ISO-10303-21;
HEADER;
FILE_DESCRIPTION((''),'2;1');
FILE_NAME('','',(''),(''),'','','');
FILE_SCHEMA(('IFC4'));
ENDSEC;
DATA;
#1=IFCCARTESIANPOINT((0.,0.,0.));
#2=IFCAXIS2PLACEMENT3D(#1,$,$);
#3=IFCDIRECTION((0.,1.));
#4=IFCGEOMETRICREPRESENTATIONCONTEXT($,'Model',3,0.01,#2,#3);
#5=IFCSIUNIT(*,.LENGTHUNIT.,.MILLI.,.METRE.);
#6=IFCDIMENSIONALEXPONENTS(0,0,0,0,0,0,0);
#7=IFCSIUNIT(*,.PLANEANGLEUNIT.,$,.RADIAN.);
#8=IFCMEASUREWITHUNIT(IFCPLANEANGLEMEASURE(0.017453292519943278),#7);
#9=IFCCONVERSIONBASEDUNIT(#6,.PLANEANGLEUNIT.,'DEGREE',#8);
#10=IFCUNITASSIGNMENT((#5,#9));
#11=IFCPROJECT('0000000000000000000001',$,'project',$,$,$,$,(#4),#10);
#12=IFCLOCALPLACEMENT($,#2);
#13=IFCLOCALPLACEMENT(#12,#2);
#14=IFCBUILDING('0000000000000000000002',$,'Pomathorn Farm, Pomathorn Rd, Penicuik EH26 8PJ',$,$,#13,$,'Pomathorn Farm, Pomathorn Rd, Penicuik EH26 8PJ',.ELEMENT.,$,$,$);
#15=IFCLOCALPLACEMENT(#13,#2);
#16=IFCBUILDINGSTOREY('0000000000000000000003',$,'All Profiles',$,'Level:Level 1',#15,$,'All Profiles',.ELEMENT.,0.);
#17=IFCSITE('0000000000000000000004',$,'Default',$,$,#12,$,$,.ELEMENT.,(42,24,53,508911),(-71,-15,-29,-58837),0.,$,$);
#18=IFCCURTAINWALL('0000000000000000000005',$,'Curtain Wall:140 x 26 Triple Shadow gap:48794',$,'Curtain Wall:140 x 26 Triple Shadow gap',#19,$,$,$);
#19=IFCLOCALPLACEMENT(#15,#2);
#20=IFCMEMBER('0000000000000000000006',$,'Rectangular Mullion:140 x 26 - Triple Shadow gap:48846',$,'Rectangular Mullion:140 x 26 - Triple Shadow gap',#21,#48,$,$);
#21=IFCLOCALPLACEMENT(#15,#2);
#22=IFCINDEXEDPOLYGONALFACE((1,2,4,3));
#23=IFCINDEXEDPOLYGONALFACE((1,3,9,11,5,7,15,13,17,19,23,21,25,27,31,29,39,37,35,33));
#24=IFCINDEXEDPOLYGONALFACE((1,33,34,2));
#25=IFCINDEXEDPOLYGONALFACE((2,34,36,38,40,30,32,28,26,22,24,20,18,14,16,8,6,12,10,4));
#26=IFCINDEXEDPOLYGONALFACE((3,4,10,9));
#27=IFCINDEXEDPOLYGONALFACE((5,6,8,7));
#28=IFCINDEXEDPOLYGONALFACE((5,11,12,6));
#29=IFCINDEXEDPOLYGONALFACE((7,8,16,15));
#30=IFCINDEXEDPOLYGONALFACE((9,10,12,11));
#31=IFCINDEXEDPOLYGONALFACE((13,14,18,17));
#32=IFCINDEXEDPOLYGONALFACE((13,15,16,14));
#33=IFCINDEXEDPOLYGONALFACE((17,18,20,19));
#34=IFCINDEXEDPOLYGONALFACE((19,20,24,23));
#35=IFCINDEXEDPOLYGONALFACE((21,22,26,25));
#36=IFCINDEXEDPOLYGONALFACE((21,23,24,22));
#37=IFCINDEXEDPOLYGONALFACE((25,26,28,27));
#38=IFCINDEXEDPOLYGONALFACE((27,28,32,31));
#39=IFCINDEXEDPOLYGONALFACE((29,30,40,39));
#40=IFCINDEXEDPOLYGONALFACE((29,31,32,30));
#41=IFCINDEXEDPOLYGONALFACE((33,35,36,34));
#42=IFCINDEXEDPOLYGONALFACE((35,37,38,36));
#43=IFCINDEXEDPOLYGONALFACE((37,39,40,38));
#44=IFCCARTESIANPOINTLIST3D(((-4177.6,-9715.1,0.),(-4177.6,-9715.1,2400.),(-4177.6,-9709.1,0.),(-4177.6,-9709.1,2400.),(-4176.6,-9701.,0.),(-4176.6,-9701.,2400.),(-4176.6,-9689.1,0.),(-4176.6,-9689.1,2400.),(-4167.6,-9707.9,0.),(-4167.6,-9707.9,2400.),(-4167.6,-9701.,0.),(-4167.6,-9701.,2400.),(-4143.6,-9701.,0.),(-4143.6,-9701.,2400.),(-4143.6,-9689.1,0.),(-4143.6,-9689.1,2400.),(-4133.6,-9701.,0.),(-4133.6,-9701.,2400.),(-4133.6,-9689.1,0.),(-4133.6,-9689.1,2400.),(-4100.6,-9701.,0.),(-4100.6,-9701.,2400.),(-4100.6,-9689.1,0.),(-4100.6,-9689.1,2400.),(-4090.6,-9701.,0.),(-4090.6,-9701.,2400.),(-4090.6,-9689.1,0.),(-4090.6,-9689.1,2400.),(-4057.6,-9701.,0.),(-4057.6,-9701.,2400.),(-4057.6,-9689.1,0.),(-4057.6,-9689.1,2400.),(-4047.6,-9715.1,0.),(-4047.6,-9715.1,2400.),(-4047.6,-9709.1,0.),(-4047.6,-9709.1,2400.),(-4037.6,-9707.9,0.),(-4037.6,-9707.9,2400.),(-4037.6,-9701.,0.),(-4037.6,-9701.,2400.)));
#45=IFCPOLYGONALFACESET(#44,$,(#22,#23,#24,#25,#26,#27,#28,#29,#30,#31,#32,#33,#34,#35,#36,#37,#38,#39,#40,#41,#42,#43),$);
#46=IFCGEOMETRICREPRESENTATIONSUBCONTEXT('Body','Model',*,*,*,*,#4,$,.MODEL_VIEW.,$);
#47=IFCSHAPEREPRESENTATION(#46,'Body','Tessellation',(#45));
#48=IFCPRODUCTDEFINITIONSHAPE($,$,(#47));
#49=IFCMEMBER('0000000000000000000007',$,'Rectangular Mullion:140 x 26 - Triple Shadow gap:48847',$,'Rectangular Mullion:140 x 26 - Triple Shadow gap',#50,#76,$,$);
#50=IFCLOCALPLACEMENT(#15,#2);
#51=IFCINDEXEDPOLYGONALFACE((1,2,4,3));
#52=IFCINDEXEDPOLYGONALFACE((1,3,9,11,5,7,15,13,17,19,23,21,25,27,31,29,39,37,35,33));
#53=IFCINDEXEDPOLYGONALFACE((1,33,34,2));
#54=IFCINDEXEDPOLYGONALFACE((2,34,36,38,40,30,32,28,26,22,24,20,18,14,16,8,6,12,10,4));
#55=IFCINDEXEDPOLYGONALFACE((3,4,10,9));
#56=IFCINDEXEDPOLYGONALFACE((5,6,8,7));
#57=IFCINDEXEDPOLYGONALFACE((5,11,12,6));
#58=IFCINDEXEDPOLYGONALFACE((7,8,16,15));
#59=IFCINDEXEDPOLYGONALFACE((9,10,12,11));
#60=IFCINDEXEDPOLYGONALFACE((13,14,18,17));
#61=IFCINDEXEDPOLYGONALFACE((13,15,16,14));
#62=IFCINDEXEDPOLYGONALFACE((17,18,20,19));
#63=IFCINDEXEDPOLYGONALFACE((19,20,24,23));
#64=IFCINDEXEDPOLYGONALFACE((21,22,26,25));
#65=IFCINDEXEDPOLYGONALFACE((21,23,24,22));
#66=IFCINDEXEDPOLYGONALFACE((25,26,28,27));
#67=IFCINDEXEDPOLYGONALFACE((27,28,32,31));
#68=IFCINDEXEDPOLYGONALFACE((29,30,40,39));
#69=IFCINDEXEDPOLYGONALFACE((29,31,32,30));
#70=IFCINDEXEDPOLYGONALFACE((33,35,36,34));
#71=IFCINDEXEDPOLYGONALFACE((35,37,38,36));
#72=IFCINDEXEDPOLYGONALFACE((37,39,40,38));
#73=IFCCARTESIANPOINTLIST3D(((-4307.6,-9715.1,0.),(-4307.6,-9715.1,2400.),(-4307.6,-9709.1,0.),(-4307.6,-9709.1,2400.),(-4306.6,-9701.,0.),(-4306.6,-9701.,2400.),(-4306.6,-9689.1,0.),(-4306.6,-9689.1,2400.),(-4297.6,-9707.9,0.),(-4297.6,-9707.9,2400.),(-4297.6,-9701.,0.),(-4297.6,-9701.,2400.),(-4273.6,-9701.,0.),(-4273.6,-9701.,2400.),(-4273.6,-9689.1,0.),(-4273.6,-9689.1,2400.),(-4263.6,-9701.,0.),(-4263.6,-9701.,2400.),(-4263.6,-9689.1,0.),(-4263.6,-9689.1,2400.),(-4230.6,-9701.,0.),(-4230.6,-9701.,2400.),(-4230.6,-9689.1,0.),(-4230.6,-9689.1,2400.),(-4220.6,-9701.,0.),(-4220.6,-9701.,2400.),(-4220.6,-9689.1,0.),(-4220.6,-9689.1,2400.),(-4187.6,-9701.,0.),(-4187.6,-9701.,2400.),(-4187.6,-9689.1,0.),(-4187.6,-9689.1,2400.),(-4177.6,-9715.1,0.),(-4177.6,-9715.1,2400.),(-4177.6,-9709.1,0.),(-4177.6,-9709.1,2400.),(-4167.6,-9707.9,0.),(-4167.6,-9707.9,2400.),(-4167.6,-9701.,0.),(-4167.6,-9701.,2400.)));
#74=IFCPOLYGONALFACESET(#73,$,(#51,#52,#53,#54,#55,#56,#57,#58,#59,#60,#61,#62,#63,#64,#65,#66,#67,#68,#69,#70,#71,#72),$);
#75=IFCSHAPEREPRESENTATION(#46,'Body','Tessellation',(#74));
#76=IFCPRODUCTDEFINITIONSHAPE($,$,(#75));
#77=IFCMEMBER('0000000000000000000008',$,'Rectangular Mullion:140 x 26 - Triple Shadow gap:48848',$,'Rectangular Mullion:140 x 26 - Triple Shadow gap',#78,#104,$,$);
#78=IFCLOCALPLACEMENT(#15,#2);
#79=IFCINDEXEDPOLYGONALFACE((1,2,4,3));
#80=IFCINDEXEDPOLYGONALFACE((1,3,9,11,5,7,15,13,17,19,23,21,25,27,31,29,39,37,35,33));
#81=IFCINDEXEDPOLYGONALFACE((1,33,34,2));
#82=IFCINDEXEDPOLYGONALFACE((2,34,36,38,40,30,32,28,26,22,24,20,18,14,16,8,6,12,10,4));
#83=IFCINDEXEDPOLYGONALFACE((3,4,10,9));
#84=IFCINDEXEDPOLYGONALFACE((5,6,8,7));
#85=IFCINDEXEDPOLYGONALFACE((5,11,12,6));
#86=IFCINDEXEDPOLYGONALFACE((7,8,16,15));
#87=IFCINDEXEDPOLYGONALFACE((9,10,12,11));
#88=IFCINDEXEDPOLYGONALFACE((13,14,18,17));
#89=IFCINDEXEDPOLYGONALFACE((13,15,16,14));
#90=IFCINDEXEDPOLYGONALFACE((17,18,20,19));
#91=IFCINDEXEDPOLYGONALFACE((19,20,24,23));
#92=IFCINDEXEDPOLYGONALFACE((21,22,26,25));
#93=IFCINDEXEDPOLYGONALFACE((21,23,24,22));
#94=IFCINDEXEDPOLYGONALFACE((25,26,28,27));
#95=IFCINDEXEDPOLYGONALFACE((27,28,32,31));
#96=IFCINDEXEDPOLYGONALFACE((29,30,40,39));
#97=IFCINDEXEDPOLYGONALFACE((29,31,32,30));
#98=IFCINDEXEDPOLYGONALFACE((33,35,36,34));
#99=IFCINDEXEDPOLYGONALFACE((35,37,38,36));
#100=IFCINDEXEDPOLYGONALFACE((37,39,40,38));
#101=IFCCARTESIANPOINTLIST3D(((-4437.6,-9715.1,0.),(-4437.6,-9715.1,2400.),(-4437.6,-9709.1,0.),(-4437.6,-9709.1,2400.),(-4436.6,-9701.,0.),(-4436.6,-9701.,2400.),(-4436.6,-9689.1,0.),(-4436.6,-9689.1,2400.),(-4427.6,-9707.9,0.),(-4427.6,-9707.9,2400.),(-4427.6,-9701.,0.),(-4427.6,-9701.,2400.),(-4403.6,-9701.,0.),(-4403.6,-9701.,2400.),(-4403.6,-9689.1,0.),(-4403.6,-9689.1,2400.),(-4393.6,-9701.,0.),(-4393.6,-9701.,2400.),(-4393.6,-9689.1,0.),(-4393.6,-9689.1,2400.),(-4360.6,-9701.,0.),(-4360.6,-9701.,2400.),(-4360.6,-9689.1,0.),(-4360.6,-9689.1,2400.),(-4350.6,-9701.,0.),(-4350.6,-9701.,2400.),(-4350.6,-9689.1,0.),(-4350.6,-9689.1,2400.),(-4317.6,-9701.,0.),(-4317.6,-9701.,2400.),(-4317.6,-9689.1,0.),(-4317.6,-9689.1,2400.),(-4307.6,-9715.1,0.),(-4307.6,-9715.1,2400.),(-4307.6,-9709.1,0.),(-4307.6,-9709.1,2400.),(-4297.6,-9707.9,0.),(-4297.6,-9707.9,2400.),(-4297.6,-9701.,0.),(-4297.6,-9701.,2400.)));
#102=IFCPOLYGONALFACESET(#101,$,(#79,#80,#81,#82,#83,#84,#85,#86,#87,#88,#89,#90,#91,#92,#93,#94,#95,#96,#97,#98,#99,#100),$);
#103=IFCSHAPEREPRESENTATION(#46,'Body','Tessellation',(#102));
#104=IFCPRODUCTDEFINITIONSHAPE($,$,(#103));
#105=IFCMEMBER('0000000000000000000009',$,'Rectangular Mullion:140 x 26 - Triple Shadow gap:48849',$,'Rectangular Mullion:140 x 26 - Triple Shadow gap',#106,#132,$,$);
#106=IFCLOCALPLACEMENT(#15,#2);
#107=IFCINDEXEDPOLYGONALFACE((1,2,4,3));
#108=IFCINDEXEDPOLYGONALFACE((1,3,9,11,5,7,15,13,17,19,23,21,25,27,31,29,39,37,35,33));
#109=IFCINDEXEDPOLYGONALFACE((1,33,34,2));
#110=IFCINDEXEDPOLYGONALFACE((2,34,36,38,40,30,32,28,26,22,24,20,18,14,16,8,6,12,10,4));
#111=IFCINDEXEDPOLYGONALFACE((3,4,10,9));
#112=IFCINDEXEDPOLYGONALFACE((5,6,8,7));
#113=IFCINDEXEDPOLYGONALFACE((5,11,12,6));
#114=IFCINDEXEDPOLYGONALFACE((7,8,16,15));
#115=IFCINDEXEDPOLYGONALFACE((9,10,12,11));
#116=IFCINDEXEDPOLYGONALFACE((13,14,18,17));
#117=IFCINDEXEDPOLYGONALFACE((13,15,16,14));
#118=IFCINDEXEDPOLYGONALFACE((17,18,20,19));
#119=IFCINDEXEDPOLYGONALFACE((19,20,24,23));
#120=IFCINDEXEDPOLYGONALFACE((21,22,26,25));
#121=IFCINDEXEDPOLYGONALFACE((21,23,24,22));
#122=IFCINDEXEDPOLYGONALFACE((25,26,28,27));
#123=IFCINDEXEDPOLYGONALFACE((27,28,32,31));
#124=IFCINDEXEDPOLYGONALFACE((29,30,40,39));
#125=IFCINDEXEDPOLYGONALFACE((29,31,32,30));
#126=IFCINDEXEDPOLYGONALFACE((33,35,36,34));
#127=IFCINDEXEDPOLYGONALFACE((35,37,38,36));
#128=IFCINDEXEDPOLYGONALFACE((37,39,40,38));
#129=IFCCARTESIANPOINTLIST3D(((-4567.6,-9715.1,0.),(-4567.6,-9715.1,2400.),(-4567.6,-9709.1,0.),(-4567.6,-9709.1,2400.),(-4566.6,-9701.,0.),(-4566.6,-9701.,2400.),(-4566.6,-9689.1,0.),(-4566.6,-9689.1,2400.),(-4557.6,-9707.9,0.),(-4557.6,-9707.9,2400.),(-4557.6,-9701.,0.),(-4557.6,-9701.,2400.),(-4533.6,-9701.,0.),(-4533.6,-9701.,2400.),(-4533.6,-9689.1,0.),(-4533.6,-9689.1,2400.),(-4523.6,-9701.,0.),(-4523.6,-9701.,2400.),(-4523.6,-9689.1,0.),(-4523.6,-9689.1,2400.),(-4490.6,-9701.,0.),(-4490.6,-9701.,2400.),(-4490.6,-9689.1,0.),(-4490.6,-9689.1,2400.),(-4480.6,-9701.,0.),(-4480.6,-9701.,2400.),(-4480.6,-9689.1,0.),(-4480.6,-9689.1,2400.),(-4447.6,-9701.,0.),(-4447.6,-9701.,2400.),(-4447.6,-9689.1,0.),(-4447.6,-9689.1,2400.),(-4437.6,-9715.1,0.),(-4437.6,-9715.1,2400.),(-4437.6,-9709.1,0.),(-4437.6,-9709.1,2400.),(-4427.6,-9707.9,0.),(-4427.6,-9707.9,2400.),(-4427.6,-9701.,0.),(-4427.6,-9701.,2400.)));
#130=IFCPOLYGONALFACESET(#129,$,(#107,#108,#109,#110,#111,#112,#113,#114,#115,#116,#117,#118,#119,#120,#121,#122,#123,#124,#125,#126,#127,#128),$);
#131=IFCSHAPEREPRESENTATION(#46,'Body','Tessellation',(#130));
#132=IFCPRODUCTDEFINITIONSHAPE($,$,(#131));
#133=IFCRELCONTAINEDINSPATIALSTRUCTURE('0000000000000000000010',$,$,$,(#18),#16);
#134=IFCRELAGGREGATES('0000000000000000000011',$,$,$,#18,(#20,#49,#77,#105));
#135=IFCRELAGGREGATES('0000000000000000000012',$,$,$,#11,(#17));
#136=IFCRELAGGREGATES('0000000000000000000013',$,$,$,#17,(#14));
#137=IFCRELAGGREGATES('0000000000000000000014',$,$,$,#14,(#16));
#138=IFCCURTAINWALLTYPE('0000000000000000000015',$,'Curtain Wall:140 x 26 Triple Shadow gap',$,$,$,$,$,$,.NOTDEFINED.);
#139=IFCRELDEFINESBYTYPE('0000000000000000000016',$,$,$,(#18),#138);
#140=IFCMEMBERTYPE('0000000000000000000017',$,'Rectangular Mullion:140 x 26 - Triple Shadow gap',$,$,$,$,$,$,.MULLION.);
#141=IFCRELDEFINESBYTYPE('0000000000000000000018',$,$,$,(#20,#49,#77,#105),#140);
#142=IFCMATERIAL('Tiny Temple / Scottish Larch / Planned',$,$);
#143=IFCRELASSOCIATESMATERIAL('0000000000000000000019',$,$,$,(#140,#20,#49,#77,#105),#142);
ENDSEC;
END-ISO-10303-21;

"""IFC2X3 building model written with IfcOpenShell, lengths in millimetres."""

from ifc_helpers import new_model, entity, si_unit, converted_unit, direction, frame, origin, place, context, subcontext, project, spatial, polyline, outline, extrude, source, transform, mapped, material, type_object, type_shapes, element, aggregate, save


model = new_model("IFC2X3")

# Units and contexts
model_context = context("Model", 3, precision=0.01, world=origin(), true_north=direction((0.0, 1.0)))
body_context = subcontext(model_context, "Body", "Model", "MODEL_VIEW")
ifc_project = project(units=[si_unit("LENGTHUNIT", "METRE", prefix="MILLI"), converted_unit("PLANEANGLEUNIT", "DEGREE", entity("IfcPlaneAngleMeasure", 0.017453292519943278), si_unit("PLANEANGLEUNIT", "RADIAN"), dimensions=[0, 0, 0, 0, 0, 0, 0])], contexts=[model_context])

# Site, building, storey
site_placement = place(None, origin())
site = spatial("IfcSite", under=ifc_project, at=site_placement, Name="Default", CompositionType="ELEMENT", RefLatitude=(42, 24, 53, 508911), RefLongitude=(-71, -15, -29, -58837), RefElevation=0.0)
building_placement = place(site_placement, origin())
building = spatial("IfcBuilding", under=site, at=building_placement, Name="Pomathorn Farm, Pomathorn Rd, Penicuik EH26 8PJ", LongName="Pomathorn Farm, Pomathorn Rd, Penicuik EH26 8PJ", CompositionType="ELEMENT")
storey_placement = place(building_placement, origin())
storey = spatial("IfcBuildingStorey", under=building, at=storey_placement, Name="All Profiles", ObjectType="Level:Level 1", LongName="All Profiles", CompositionType="ELEMENT", Elevation=0.0)

# Curtain wall, members
ifc_material = material(Name="Tiny Temple / Scottish Larch / Planned")
curtain_wall_type_1 = type_object("IfcCurtainWallType", Name="Curtain Wall:140 x 26 Triple Shadow gap", PredefinedType="NOTDEFINED")
curtain_wall_1_placement = place(storey_placement, origin())
curtain_wall_1 = element("IfcCurtainWall", 1, at=curtain_wall_1_placement, inside=storey, type_object=curtain_wall_type_1, Name="Curtain Wall:140 x 26 Triple Shadow gap:48794", ObjectType="Curtain Wall:140 x 26 Triple Shadow gap")
member_type_1 = type_object("IfcMemberType", Name="Rectangular Mullion:140 x 26 - Triple Shadow gap", PredefinedType="MULLION", material=ifc_material)
shared_shape_1 = source(origin(), body_context, "Body", "SweptSolid", [
    extrude(outline(polyline([(-64.9, -0.9), (-65.6, -6.8), (63.4, -22.7), (64.1, -16.7), (74.2, -16.7), (75.1, -9.8), (55.2, -7.4), (56.7, 4.3), (23.9, 8.4), (22.5, -3.4), (12.5, -2.2), (14.0, 9.6), (-18.8, 13.6), (-20.2, 1.9), (-30.1, 3.1), (-28.7, 14.8), (-61.5, 18.8), (-62.9, 7.1), (-54.0, 6.0), (-54.8, -0.9), (-64.9, -0.9)])), frame((-75.7, -14.8, -2400.0), z_axis=(0.0, 0.0, -1.0), x_axis=(0.992546, -0.121869, 0.0)), (0.0, 0.0, -1.0), 2400.0),
])
type_shapes(member_type_1, [shared_shape_1])
member_1_placement = place(curtain_wall_1_placement, frame((-4037.6, -9715.1, 0.0), z_axis=(0.0, 0.0, -1.0), x_axis=(1.0, 0.0, 0.0)))
member_1 = element("IfcMember", 2, at=member_1_placement, type_object=member_type_1, material=ifc_material, Name="Rectangular Mullion:140 x 26 - Triple Shadow gap:48846", ObjectType="Rectangular Mullion:140 x 26 - Triple Shadow gap", context=body_context, shape_type="MappedRepresentation", body=[
    mapped(shared_shape_1, transform((0.0, 0.0, 0.0), scale=1.0)),
])
member_2_placement = place(curtain_wall_1_placement, frame((-4167.6, -9715.1, 0.0), z_axis=(0.0, 0.0, -1.0), x_axis=(1.0, 0.0, 0.0)))
member_2 = element("IfcMember", 3, at=member_2_placement, type_object=member_type_1, material=ifc_material, Name="Rectangular Mullion:140 x 26 - Triple Shadow gap:48847", ObjectType="Rectangular Mullion:140 x 26 - Triple Shadow gap", context=body_context, shape_type="MappedRepresentation", body=[
    mapped(shared_shape_1, transform((0.0, 0.0, 0.0), scale=1.0)),
])
member_3_placement = place(curtain_wall_1_placement, frame((-4297.6, -9715.1, 0.0), z_axis=(0.0, 0.0, -1.0), x_axis=(1.0, 0.0, 0.0)))
member_3 = element("IfcMember", 4, at=member_3_placement, type_object=member_type_1, material=ifc_material, Name="Rectangular Mullion:140 x 26 - Triple Shadow gap:48848", ObjectType="Rectangular Mullion:140 x 26 - Triple Shadow gap", context=body_context, shape_type="MappedRepresentation", body=[
    mapped(shared_shape_1, transform((0.0, 0.0, 0.0), scale=1.0)),
])
member_4_placement = place(curtain_wall_1_placement, frame((-4427.6, -9715.1, 0.0), z_axis=(0.0, 0.0, -1.0), x_axis=(1.0, 0.0, 0.0)))
member_4 = element("IfcMember", 5, at=member_4_placement, type_object=member_type_1, material=ifc_material, Name="Rectangular Mullion:140 x 26 - Triple Shadow gap:48849", ObjectType="Rectangular Mullion:140 x 26 - Triple Shadow gap", context=body_context, shape_type="MappedRepresentation", body=[
    mapped(shared_shape_1, transform((0.0, 0.0, 0.0), scale=1.0)),
])
aggregate(curtain_wall_1, [member_1, member_2, member_3, member_4])

save(model, "model.ifc")
